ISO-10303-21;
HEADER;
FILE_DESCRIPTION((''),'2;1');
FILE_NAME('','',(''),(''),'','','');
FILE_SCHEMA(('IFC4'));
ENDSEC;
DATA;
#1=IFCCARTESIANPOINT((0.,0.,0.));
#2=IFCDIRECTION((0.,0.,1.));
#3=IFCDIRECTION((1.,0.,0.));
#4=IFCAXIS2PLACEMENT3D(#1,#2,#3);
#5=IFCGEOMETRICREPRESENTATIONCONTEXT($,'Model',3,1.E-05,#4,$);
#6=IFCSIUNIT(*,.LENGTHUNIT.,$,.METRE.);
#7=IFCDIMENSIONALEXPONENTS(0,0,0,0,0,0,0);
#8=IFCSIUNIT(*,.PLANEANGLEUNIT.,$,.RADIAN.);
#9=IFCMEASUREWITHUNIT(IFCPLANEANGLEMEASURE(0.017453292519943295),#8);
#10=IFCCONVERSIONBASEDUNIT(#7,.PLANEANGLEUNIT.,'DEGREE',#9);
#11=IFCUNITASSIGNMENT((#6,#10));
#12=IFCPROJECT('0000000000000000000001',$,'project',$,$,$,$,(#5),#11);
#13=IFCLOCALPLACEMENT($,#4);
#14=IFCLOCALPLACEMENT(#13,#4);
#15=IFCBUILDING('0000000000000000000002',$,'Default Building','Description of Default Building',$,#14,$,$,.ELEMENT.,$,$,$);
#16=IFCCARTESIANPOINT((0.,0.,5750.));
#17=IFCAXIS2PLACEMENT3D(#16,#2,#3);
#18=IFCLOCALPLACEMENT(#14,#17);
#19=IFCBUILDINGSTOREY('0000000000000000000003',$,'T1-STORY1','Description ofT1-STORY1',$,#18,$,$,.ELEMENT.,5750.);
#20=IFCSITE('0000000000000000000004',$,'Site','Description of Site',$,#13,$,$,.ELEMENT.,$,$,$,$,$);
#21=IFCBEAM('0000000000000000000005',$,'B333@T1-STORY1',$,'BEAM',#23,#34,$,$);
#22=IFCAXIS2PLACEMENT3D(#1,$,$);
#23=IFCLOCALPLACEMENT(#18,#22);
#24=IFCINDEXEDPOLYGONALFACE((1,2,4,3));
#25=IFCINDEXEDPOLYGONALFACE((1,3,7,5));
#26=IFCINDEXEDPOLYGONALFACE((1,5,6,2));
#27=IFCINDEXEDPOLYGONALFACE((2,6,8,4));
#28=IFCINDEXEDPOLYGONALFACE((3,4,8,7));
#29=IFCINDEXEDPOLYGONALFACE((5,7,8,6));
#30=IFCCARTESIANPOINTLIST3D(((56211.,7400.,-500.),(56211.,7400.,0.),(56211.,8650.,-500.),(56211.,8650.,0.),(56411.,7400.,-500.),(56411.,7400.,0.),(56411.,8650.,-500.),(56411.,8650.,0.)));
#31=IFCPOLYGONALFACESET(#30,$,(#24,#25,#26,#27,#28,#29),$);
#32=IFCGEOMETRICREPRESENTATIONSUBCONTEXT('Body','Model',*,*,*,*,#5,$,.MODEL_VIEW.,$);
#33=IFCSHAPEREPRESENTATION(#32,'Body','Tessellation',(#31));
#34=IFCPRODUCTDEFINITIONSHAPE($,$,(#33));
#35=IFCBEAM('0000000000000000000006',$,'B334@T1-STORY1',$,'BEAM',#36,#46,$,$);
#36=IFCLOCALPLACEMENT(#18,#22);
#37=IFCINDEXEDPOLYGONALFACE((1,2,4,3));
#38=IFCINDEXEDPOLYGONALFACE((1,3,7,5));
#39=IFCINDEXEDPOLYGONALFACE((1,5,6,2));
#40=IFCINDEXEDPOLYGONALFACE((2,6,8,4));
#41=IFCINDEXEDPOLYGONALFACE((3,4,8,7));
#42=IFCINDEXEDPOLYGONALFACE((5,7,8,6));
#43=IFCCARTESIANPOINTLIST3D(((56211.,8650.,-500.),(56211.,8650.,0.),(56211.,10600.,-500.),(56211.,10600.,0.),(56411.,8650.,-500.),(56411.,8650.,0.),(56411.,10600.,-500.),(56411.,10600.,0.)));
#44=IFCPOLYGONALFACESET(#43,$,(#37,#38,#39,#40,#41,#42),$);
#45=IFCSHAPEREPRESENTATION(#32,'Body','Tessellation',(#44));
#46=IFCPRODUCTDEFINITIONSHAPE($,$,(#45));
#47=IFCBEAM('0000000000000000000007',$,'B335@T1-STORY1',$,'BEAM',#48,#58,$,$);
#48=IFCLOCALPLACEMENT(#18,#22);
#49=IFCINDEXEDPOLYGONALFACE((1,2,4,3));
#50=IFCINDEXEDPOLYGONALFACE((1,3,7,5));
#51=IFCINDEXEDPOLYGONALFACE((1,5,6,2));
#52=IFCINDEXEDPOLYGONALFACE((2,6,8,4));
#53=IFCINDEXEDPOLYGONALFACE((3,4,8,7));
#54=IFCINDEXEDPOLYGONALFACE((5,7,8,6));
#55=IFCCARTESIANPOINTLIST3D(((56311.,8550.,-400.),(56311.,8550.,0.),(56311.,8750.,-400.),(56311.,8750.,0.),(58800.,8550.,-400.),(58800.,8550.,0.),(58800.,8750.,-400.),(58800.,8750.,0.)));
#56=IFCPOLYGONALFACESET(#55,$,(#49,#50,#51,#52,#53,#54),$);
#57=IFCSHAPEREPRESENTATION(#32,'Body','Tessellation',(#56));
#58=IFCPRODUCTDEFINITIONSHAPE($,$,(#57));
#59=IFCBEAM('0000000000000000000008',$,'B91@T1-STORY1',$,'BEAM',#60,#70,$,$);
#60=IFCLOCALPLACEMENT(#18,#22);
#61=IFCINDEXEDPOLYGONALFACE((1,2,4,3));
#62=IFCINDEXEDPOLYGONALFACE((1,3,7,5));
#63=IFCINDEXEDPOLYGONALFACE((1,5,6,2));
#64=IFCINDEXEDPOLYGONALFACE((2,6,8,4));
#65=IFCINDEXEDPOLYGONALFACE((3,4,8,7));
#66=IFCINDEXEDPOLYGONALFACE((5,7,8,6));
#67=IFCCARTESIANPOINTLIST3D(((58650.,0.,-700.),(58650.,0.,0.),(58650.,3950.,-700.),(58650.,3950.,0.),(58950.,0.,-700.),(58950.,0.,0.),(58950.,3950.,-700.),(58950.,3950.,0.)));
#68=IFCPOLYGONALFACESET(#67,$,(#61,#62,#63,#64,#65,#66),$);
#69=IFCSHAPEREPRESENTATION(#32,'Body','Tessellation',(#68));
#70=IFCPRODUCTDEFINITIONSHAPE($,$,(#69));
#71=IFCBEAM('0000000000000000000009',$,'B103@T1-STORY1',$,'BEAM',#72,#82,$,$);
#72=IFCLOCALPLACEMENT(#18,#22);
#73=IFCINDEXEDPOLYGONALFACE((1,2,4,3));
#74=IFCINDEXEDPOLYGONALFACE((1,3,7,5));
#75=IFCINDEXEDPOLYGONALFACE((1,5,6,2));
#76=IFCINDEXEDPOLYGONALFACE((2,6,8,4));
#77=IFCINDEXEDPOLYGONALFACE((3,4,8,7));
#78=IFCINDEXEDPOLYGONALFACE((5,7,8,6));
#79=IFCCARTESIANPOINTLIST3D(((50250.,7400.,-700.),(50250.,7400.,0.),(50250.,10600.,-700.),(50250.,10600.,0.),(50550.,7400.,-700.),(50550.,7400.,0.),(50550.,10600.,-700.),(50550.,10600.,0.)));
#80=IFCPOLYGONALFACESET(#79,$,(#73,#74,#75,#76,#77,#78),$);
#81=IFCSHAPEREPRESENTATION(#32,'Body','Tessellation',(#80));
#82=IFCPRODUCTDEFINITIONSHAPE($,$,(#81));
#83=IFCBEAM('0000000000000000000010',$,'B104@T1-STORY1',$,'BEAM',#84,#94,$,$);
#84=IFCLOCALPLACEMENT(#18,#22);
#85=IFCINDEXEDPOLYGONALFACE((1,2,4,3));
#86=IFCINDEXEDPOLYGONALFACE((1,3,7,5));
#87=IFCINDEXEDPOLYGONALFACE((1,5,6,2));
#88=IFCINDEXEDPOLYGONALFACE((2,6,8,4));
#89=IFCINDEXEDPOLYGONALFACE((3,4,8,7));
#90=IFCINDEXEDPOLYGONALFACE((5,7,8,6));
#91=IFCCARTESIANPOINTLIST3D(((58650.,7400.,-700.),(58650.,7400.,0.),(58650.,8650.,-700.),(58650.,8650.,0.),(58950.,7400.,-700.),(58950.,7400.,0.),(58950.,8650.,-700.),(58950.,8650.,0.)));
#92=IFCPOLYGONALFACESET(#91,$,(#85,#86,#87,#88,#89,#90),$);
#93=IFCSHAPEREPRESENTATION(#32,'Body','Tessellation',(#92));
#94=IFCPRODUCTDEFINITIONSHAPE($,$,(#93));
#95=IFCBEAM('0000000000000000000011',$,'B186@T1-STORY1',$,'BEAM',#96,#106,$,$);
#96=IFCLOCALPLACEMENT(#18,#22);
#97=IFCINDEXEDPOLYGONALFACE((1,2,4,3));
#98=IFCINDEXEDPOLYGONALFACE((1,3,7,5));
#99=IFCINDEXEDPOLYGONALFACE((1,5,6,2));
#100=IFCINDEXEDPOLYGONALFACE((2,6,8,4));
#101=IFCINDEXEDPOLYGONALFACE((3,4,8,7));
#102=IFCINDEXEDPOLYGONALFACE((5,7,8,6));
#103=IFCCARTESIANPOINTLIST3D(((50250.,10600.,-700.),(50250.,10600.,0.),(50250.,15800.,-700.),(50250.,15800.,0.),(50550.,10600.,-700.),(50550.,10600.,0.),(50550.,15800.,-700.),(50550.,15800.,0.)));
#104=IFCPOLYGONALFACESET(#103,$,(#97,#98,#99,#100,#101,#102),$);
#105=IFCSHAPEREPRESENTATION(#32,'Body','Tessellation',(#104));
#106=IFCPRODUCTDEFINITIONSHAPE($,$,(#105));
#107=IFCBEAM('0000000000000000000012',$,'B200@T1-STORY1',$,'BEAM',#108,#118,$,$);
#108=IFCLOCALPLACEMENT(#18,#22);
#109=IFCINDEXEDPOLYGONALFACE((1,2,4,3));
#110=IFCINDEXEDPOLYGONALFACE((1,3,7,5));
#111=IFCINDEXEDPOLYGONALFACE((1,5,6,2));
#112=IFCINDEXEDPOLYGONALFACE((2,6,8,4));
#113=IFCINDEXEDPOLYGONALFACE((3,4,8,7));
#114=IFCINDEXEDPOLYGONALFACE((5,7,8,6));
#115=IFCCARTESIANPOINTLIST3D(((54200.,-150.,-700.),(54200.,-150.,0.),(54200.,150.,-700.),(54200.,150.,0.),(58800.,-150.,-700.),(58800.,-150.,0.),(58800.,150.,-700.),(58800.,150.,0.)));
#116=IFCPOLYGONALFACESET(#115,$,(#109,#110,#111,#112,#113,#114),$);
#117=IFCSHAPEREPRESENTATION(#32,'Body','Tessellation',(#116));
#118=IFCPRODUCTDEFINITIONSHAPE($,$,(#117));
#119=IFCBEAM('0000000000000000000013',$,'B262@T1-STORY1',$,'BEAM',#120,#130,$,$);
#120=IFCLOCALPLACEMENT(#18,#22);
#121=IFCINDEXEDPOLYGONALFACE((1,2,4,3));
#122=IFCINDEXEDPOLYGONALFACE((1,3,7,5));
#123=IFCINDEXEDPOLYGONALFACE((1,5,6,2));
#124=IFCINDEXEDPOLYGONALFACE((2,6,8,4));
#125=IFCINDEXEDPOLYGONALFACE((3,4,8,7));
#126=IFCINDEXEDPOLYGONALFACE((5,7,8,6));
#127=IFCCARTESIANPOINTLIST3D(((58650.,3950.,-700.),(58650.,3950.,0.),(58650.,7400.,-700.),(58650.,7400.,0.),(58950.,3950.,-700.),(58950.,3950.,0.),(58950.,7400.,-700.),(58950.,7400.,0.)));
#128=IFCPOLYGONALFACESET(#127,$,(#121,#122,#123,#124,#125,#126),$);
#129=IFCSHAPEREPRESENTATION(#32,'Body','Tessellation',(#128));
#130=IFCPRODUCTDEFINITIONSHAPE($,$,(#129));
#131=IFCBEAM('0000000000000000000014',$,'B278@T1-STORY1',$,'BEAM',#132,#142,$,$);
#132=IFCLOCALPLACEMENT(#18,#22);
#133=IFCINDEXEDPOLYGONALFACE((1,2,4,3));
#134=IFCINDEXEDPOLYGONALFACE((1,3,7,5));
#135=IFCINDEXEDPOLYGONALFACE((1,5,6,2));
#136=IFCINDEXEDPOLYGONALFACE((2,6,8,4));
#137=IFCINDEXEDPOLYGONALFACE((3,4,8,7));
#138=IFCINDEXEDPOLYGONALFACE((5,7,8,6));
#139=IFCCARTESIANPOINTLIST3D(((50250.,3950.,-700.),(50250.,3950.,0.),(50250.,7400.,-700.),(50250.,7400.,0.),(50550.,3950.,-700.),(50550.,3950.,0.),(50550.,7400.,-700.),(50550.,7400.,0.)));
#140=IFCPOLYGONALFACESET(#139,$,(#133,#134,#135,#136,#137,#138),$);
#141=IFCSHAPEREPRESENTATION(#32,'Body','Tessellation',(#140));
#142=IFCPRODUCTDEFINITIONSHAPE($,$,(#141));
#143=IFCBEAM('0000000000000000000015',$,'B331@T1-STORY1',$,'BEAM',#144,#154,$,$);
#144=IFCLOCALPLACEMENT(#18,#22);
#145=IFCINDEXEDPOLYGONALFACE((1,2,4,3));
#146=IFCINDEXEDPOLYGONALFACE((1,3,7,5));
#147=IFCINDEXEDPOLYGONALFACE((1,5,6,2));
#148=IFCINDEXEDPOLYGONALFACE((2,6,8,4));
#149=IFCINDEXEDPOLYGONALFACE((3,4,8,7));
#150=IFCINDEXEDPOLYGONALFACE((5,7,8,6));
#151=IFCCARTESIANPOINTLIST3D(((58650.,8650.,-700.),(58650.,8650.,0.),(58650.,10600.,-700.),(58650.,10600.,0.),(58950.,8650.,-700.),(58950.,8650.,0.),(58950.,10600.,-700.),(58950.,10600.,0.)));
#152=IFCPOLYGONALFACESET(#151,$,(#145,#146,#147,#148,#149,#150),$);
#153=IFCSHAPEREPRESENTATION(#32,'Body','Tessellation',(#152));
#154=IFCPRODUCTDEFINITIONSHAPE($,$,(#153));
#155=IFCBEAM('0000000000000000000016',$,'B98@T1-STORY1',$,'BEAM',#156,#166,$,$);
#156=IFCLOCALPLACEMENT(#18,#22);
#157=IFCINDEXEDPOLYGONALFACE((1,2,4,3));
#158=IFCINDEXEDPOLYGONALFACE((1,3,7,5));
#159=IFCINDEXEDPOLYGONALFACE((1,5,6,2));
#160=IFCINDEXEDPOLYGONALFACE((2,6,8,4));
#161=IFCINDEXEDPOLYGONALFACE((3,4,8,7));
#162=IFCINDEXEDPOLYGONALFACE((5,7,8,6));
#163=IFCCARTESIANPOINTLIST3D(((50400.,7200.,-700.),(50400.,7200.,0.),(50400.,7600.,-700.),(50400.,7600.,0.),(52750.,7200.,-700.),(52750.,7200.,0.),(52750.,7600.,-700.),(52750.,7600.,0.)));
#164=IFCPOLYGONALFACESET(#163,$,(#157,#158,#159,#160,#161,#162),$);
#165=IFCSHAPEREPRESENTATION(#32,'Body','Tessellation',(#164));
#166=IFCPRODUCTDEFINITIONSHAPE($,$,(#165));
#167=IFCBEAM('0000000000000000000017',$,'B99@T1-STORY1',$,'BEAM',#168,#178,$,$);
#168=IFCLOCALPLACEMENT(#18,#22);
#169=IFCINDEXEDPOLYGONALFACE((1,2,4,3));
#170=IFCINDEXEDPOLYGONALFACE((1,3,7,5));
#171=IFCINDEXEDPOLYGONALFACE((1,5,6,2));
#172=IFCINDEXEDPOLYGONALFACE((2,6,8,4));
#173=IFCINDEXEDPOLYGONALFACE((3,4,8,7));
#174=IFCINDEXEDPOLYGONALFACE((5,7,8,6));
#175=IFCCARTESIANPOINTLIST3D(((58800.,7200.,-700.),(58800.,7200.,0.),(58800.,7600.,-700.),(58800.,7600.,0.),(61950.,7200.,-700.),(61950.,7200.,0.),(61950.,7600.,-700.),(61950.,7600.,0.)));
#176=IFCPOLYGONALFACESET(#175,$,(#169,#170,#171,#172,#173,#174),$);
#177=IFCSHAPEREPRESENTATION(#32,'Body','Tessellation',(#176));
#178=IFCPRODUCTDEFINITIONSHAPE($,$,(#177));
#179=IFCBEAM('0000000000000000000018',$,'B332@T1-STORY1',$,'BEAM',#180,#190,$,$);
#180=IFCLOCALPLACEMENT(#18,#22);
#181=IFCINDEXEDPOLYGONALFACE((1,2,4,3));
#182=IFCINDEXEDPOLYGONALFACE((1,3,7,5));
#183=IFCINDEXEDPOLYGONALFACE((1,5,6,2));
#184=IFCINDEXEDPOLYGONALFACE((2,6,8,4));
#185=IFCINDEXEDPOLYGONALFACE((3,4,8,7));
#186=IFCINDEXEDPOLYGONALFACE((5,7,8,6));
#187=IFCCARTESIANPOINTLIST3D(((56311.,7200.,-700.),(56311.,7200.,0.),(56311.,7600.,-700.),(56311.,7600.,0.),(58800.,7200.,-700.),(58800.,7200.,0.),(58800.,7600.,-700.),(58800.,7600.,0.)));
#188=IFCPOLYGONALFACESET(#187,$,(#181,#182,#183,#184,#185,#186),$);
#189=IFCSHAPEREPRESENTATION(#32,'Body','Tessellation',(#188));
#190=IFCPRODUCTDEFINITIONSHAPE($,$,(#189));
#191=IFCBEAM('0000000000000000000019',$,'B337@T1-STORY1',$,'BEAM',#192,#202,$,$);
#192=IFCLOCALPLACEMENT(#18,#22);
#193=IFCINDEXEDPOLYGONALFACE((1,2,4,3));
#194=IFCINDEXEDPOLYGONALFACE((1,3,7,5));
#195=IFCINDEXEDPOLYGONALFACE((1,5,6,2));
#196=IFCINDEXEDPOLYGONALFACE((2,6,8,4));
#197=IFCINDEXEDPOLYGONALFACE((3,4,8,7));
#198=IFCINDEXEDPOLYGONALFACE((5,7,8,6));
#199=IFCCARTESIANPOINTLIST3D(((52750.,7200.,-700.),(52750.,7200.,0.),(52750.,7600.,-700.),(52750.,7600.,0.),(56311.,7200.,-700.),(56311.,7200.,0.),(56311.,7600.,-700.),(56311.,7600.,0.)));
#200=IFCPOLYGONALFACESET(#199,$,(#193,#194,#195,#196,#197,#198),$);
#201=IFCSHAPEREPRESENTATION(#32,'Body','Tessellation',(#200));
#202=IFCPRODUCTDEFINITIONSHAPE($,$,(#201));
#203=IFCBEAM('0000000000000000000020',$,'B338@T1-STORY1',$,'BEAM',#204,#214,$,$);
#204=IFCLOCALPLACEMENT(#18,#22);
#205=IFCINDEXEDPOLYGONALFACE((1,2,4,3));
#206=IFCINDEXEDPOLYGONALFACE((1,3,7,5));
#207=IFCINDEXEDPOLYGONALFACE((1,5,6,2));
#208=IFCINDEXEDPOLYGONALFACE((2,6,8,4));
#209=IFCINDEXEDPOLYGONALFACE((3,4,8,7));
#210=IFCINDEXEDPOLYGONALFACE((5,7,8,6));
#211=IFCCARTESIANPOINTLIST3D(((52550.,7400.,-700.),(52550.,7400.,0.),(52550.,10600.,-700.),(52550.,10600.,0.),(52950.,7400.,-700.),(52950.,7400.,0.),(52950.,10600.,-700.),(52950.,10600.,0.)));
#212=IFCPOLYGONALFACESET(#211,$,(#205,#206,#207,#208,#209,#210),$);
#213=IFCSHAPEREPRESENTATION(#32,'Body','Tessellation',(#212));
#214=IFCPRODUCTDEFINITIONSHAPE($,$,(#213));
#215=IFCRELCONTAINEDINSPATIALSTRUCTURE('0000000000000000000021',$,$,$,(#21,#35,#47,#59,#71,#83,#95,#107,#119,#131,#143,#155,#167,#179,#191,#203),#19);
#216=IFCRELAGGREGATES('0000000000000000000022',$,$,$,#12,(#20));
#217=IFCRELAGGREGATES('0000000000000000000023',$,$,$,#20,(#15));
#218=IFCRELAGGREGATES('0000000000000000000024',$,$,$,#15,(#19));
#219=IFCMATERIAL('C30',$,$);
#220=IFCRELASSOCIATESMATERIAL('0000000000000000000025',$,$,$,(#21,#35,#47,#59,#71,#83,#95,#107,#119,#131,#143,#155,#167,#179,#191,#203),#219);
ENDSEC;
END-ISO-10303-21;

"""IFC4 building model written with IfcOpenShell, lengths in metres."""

from ifc_helpers import new_model, entity, si_unit, converted_unit, frame, origin_with_axes, place, context, subcontext, project, spatial, rectangle, extrude, material, element, save


model = new_model("IFC4")

# Units and contexts
model_context = context("Model", 3, precision=1e-05, world=origin_with_axes())
body_context = subcontext(model_context, "Body", "Model", "MODEL_VIEW")
ifc_project = project(units=[si_unit("LENGTHUNIT", "METRE"), converted_unit("PLANEANGLEUNIT", "DEGREE", entity("IfcPlaneAngleMeasure", 0.017453292519943295), si_unit("PLANEANGLEUNIT", "RADIAN"), dimensions=[0, 0, 0, 0, 0, 0, 0])], contexts=[model_context])

# Site, building, storey
site_placement = place(None, origin_with_axes())
site = spatial("IfcSite", under=ifc_project, at=site_placement, Name="Site", Description="Description of Site", CompositionType="ELEMENT")
building_placement = place(site_placement, origin_with_axes())
building = spatial("IfcBuilding", under=site, at=building_placement, Name="Default Building", Description="Description of Default Building", CompositionType="ELEMENT")
storey_placement = place(building_placement, frame((0.0, 0.0, 5750.0), z_axis=(0.0, 0.0, 1.0), x_axis=(1.0, 0.0, 0.0)))
storey = spatial("IfcBuildingStorey", under=building, at=storey_placement, Name="T1-STORY1", Description="Description ofT1-STORY1", CompositionType="ELEMENT", Elevation=5750.0)

# Beams
ifc_material_1 = material(Name="C30")
beam_1_placement = place(storey_placement, frame((56311.0, 7400.0, -250.0), z_axis=(0.0, 1.0, 0.0), x_axis=(-1.0, 0.0, 0.0)))
element("IfcBeam", 1, at=beam_1_placement, inside=storey, material=ifc_material_1, Name="B333@T1-STORY1", ObjectType="BEAM", context=body_context, shape_type="SweptSolid", body=[
    extrude(rectangle(XDim=200.0, YDim=500.0), origin_with_axes(), (0.0, 0.0, 1.0), 1250.0),
])
beam_2_placement = place(storey_placement, frame((56311.0, 8650.0, -250.0), z_axis=(0.0, 1.0, 0.0), x_axis=(-1.0, 0.0, 0.0)))
element("IfcBeam", 2, at=beam_2_placement, inside=storey, material=ifc_material_1, Name="B334@T1-STORY1", ObjectType="BEAM", context=body_context, shape_type="SweptSolid", body=[
    extrude(rectangle(XDim=200.0, YDim=500.0), origin_with_axes(), (0.0, 0.0, 1.0), 1950.0),
])
beam_3_placement = place(storey_placement, frame((56311.0, 8650.0, -200.0), z_axis=(1.0, 0.0, 0.0), x_axis=(0.0, 1.0, 0.0)))
element("IfcBeam", 3, at=beam_3_placement, inside=storey, material=ifc_material_1, Name="B335@T1-STORY1", ObjectType="BEAM", context=body_context, shape_type="SweptSolid", body=[
    extrude(rectangle(XDim=200.0, YDim=400.0), origin_with_axes(), (0.0, 0.0, 1.0), 2489.0),
])
beam_4_placement = place(storey_placement, frame((58800.0, 0.0, -350.0), z_axis=(0.0, 1.0, 0.0), x_axis=(-1.0, 0.0, 0.0)))
element("IfcBeam", 4, at=beam_4_placement, inside=storey, material=ifc_material_1, Name="B91@T1-STORY1", ObjectType="BEAM", context=body_context, shape_type="SweptSolid", body=[
    extrude(rectangle(XDim=300.0, YDim=700.0), origin_with_axes(), (0.0, 0.0, 1.0), 3950.0),
])
beam_5_placement = place(storey_placement, frame((50400.0, 7400.0, -350.0), z_axis=(0.0, 1.0, 0.0), x_axis=(-1.0, 0.0, 0.0)))
element("IfcBeam", 5, at=beam_5_placement, inside=storey, material=ifc_material_1, Name="B103@T1-STORY1", ObjectType="BEAM", context=body_context, shape_type="SweptSolid", body=[
    extrude(rectangle(XDim=300.0, YDim=700.0), origin_with_axes(), (0.0, 0.0, 1.0), 3200.0),
])
beam_6_placement = place(storey_placement, frame((58800.0, 7400.0, -350.0), z_axis=(0.0, 1.0, 0.0), x_axis=(-1.0, 0.0, 0.0)))
element("IfcBeam", 6, at=beam_6_placement, inside=storey, material=ifc_material_1, Name="B104@T1-STORY1", ObjectType="BEAM", context=body_context, shape_type="SweptSolid", body=[
    extrude(rectangle(XDim=300.0, YDim=700.0), origin_with_axes(), (0.0, 0.0, 1.0), 1250.0),
])
beam_7_placement = place(storey_placement, frame((50400.0, 10600.0, -350.0), z_axis=(0.0, 1.0, 0.0), x_axis=(-1.0, 0.0, 0.0)))
element("IfcBeam", 7, at=beam_7_placement, inside=storey, material=ifc_material_1, Name="B186@T1-STORY1", ObjectType="BEAM", context=body_context, shape_type="SweptSolid", body=[
    extrude(rectangle(XDim=300.0, YDim=700.0), origin_with_axes(), (0.0, 0.0, 1.0), 5200.0),
])
beam_8_placement = place(storey_placement, frame((54200.0, 0.0, -350.0), z_axis=(1.0, 0.0, 0.0), x_axis=(0.0, 1.0, 0.0)))
element("IfcBeam", 8, at=beam_8_placement, inside=storey, material=ifc_material_1, Name="B200@T1-STORY1", ObjectType="BEAM", context=body_context, shape_type="SweptSolid", body=[
    extrude(rectangle(XDim=300.0, YDim=700.0), origin_with_axes(), (0.0, 0.0, 1.0), 4600.0),
])
for number, where, z_axis, x_axis, name in (
    (9, (58800.0, 3950.0, -350.0), (0.0, 1.0, 0.0), (-1.0, 0.0, 0.0), "B262@T1-STORY1"),
    (10, (50400.0, 3950.0, -350.0), (0.0, 1.0, 0.0), (-1.0, 0.0, 0.0), "B278@T1-STORY1"),
):
    element("IfcBeam", number, at=place(storey_placement, frame(where, z_axis=z_axis, x_axis=x_axis)), inside=storey, material=ifc_material_1, Name=name, ObjectType="BEAM", context=body_context, shape_type="SweptSolid", body=[
        extrude(rectangle(XDim=300.0, YDim=700.0), origin_with_axes(), (0.0, 0.0, 1.0), 3450.0),
    ])
beam_9_placement = place(storey_placement, frame((58800.0, 8650.0, -350.0), z_axis=(0.0, 1.0, 0.0), x_axis=(-1.0, 0.0, 0.0)))
element("IfcBeam", 11, at=beam_9_placement, inside=storey, material=ifc_material_1, Name="B331@T1-STORY1", ObjectType="BEAM", context=body_context, shape_type="SweptSolid", body=[
    extrude(rectangle(XDim=300.0, YDim=700.0), origin_with_axes(), (0.0, 0.0, 1.0), 1950.0),
])
beam_10_placement = place(storey_placement, frame((50400.0, 7400.0, -350.0), z_axis=(1.0, 0.0, 0.0), x_axis=(0.0, 1.0, 0.0)))
element("IfcBeam", 12, at=beam_10_placement, inside=storey, material=ifc_material_1, Name="B98@T1-STORY1", ObjectType="BEAM", context=body_context, shape_type="SweptSolid", body=[
    extrude(rectangle(XDim=400.0, YDim=700.0), origin_with_axes(), (0.0, 0.0, 1.0), 2350.0),
])
beam_11_placement = place(storey_placement, frame((58800.0, 7400.0, -350.0), z_axis=(1.0, 0.0, 0.0), x_axis=(0.0, 1.0, 0.0)))
element("IfcBeam", 13, at=beam_11_placement, inside=storey, material=ifc_material_1, Name="B99@T1-STORY1", ObjectType="BEAM", context=body_context, shape_type="SweptSolid", body=[
    extrude(rectangle(XDim=400.0, YDim=700.0), origin_with_axes(), (0.0, 0.0, 1.0), 3150.0),
])
beam_12_placement = place(storey_placement, frame((56311.0, 7400.0, -350.0), z_axis=(1.0, 0.0, 0.0), x_axis=(0.0, 1.0, 0.0)))
element("IfcBeam", 14, at=beam_12_placement, inside=storey, material=ifc_material_1, Name="B332@T1-STORY1", ObjectType="BEAM", context=body_context, shape_type="SweptSolid", body=[
    extrude(rectangle(XDim=400.0, YDim=700.0), origin_with_axes(), (0.0, 0.0, 1.0), 2489.0),
])
beam_13_placement = place(storey_placement, frame((52750.0, 7400.0, -350.0), z_axis=(1.0, 0.0, 0.0), x_axis=(0.0, 1.0, 0.0)))
element("IfcBeam", 15, at=beam_13_placement, inside=storey, material=ifc_material_1, Name="B337@T1-STORY1", ObjectType="BEAM", context=body_context, shape_type="SweptSolid", body=[
    extrude(rectangle(XDim=400.0, YDim=700.0), origin_with_axes(), (0.0, 0.0, 1.0), 3561.0),
])
beam_14_placement = place(storey_placement, frame((52750.0, 7400.0, -350.0), z_axis=(0.0, 1.0, 0.0), x_axis=(-1.0, 0.0, 0.0)))
element("IfcBeam", 16, at=beam_14_placement, inside=storey, material=ifc_material_1, Name="B338@T1-STORY1", ObjectType="BEAM", context=body_context, shape_type="SweptSolid", body=[
    extrude(rectangle(XDim=400.0, YDim=700.0), origin_with_axes(), (0.0, 0.0, 1.0), 3200.0),
])

save(model, "model.ifc")
